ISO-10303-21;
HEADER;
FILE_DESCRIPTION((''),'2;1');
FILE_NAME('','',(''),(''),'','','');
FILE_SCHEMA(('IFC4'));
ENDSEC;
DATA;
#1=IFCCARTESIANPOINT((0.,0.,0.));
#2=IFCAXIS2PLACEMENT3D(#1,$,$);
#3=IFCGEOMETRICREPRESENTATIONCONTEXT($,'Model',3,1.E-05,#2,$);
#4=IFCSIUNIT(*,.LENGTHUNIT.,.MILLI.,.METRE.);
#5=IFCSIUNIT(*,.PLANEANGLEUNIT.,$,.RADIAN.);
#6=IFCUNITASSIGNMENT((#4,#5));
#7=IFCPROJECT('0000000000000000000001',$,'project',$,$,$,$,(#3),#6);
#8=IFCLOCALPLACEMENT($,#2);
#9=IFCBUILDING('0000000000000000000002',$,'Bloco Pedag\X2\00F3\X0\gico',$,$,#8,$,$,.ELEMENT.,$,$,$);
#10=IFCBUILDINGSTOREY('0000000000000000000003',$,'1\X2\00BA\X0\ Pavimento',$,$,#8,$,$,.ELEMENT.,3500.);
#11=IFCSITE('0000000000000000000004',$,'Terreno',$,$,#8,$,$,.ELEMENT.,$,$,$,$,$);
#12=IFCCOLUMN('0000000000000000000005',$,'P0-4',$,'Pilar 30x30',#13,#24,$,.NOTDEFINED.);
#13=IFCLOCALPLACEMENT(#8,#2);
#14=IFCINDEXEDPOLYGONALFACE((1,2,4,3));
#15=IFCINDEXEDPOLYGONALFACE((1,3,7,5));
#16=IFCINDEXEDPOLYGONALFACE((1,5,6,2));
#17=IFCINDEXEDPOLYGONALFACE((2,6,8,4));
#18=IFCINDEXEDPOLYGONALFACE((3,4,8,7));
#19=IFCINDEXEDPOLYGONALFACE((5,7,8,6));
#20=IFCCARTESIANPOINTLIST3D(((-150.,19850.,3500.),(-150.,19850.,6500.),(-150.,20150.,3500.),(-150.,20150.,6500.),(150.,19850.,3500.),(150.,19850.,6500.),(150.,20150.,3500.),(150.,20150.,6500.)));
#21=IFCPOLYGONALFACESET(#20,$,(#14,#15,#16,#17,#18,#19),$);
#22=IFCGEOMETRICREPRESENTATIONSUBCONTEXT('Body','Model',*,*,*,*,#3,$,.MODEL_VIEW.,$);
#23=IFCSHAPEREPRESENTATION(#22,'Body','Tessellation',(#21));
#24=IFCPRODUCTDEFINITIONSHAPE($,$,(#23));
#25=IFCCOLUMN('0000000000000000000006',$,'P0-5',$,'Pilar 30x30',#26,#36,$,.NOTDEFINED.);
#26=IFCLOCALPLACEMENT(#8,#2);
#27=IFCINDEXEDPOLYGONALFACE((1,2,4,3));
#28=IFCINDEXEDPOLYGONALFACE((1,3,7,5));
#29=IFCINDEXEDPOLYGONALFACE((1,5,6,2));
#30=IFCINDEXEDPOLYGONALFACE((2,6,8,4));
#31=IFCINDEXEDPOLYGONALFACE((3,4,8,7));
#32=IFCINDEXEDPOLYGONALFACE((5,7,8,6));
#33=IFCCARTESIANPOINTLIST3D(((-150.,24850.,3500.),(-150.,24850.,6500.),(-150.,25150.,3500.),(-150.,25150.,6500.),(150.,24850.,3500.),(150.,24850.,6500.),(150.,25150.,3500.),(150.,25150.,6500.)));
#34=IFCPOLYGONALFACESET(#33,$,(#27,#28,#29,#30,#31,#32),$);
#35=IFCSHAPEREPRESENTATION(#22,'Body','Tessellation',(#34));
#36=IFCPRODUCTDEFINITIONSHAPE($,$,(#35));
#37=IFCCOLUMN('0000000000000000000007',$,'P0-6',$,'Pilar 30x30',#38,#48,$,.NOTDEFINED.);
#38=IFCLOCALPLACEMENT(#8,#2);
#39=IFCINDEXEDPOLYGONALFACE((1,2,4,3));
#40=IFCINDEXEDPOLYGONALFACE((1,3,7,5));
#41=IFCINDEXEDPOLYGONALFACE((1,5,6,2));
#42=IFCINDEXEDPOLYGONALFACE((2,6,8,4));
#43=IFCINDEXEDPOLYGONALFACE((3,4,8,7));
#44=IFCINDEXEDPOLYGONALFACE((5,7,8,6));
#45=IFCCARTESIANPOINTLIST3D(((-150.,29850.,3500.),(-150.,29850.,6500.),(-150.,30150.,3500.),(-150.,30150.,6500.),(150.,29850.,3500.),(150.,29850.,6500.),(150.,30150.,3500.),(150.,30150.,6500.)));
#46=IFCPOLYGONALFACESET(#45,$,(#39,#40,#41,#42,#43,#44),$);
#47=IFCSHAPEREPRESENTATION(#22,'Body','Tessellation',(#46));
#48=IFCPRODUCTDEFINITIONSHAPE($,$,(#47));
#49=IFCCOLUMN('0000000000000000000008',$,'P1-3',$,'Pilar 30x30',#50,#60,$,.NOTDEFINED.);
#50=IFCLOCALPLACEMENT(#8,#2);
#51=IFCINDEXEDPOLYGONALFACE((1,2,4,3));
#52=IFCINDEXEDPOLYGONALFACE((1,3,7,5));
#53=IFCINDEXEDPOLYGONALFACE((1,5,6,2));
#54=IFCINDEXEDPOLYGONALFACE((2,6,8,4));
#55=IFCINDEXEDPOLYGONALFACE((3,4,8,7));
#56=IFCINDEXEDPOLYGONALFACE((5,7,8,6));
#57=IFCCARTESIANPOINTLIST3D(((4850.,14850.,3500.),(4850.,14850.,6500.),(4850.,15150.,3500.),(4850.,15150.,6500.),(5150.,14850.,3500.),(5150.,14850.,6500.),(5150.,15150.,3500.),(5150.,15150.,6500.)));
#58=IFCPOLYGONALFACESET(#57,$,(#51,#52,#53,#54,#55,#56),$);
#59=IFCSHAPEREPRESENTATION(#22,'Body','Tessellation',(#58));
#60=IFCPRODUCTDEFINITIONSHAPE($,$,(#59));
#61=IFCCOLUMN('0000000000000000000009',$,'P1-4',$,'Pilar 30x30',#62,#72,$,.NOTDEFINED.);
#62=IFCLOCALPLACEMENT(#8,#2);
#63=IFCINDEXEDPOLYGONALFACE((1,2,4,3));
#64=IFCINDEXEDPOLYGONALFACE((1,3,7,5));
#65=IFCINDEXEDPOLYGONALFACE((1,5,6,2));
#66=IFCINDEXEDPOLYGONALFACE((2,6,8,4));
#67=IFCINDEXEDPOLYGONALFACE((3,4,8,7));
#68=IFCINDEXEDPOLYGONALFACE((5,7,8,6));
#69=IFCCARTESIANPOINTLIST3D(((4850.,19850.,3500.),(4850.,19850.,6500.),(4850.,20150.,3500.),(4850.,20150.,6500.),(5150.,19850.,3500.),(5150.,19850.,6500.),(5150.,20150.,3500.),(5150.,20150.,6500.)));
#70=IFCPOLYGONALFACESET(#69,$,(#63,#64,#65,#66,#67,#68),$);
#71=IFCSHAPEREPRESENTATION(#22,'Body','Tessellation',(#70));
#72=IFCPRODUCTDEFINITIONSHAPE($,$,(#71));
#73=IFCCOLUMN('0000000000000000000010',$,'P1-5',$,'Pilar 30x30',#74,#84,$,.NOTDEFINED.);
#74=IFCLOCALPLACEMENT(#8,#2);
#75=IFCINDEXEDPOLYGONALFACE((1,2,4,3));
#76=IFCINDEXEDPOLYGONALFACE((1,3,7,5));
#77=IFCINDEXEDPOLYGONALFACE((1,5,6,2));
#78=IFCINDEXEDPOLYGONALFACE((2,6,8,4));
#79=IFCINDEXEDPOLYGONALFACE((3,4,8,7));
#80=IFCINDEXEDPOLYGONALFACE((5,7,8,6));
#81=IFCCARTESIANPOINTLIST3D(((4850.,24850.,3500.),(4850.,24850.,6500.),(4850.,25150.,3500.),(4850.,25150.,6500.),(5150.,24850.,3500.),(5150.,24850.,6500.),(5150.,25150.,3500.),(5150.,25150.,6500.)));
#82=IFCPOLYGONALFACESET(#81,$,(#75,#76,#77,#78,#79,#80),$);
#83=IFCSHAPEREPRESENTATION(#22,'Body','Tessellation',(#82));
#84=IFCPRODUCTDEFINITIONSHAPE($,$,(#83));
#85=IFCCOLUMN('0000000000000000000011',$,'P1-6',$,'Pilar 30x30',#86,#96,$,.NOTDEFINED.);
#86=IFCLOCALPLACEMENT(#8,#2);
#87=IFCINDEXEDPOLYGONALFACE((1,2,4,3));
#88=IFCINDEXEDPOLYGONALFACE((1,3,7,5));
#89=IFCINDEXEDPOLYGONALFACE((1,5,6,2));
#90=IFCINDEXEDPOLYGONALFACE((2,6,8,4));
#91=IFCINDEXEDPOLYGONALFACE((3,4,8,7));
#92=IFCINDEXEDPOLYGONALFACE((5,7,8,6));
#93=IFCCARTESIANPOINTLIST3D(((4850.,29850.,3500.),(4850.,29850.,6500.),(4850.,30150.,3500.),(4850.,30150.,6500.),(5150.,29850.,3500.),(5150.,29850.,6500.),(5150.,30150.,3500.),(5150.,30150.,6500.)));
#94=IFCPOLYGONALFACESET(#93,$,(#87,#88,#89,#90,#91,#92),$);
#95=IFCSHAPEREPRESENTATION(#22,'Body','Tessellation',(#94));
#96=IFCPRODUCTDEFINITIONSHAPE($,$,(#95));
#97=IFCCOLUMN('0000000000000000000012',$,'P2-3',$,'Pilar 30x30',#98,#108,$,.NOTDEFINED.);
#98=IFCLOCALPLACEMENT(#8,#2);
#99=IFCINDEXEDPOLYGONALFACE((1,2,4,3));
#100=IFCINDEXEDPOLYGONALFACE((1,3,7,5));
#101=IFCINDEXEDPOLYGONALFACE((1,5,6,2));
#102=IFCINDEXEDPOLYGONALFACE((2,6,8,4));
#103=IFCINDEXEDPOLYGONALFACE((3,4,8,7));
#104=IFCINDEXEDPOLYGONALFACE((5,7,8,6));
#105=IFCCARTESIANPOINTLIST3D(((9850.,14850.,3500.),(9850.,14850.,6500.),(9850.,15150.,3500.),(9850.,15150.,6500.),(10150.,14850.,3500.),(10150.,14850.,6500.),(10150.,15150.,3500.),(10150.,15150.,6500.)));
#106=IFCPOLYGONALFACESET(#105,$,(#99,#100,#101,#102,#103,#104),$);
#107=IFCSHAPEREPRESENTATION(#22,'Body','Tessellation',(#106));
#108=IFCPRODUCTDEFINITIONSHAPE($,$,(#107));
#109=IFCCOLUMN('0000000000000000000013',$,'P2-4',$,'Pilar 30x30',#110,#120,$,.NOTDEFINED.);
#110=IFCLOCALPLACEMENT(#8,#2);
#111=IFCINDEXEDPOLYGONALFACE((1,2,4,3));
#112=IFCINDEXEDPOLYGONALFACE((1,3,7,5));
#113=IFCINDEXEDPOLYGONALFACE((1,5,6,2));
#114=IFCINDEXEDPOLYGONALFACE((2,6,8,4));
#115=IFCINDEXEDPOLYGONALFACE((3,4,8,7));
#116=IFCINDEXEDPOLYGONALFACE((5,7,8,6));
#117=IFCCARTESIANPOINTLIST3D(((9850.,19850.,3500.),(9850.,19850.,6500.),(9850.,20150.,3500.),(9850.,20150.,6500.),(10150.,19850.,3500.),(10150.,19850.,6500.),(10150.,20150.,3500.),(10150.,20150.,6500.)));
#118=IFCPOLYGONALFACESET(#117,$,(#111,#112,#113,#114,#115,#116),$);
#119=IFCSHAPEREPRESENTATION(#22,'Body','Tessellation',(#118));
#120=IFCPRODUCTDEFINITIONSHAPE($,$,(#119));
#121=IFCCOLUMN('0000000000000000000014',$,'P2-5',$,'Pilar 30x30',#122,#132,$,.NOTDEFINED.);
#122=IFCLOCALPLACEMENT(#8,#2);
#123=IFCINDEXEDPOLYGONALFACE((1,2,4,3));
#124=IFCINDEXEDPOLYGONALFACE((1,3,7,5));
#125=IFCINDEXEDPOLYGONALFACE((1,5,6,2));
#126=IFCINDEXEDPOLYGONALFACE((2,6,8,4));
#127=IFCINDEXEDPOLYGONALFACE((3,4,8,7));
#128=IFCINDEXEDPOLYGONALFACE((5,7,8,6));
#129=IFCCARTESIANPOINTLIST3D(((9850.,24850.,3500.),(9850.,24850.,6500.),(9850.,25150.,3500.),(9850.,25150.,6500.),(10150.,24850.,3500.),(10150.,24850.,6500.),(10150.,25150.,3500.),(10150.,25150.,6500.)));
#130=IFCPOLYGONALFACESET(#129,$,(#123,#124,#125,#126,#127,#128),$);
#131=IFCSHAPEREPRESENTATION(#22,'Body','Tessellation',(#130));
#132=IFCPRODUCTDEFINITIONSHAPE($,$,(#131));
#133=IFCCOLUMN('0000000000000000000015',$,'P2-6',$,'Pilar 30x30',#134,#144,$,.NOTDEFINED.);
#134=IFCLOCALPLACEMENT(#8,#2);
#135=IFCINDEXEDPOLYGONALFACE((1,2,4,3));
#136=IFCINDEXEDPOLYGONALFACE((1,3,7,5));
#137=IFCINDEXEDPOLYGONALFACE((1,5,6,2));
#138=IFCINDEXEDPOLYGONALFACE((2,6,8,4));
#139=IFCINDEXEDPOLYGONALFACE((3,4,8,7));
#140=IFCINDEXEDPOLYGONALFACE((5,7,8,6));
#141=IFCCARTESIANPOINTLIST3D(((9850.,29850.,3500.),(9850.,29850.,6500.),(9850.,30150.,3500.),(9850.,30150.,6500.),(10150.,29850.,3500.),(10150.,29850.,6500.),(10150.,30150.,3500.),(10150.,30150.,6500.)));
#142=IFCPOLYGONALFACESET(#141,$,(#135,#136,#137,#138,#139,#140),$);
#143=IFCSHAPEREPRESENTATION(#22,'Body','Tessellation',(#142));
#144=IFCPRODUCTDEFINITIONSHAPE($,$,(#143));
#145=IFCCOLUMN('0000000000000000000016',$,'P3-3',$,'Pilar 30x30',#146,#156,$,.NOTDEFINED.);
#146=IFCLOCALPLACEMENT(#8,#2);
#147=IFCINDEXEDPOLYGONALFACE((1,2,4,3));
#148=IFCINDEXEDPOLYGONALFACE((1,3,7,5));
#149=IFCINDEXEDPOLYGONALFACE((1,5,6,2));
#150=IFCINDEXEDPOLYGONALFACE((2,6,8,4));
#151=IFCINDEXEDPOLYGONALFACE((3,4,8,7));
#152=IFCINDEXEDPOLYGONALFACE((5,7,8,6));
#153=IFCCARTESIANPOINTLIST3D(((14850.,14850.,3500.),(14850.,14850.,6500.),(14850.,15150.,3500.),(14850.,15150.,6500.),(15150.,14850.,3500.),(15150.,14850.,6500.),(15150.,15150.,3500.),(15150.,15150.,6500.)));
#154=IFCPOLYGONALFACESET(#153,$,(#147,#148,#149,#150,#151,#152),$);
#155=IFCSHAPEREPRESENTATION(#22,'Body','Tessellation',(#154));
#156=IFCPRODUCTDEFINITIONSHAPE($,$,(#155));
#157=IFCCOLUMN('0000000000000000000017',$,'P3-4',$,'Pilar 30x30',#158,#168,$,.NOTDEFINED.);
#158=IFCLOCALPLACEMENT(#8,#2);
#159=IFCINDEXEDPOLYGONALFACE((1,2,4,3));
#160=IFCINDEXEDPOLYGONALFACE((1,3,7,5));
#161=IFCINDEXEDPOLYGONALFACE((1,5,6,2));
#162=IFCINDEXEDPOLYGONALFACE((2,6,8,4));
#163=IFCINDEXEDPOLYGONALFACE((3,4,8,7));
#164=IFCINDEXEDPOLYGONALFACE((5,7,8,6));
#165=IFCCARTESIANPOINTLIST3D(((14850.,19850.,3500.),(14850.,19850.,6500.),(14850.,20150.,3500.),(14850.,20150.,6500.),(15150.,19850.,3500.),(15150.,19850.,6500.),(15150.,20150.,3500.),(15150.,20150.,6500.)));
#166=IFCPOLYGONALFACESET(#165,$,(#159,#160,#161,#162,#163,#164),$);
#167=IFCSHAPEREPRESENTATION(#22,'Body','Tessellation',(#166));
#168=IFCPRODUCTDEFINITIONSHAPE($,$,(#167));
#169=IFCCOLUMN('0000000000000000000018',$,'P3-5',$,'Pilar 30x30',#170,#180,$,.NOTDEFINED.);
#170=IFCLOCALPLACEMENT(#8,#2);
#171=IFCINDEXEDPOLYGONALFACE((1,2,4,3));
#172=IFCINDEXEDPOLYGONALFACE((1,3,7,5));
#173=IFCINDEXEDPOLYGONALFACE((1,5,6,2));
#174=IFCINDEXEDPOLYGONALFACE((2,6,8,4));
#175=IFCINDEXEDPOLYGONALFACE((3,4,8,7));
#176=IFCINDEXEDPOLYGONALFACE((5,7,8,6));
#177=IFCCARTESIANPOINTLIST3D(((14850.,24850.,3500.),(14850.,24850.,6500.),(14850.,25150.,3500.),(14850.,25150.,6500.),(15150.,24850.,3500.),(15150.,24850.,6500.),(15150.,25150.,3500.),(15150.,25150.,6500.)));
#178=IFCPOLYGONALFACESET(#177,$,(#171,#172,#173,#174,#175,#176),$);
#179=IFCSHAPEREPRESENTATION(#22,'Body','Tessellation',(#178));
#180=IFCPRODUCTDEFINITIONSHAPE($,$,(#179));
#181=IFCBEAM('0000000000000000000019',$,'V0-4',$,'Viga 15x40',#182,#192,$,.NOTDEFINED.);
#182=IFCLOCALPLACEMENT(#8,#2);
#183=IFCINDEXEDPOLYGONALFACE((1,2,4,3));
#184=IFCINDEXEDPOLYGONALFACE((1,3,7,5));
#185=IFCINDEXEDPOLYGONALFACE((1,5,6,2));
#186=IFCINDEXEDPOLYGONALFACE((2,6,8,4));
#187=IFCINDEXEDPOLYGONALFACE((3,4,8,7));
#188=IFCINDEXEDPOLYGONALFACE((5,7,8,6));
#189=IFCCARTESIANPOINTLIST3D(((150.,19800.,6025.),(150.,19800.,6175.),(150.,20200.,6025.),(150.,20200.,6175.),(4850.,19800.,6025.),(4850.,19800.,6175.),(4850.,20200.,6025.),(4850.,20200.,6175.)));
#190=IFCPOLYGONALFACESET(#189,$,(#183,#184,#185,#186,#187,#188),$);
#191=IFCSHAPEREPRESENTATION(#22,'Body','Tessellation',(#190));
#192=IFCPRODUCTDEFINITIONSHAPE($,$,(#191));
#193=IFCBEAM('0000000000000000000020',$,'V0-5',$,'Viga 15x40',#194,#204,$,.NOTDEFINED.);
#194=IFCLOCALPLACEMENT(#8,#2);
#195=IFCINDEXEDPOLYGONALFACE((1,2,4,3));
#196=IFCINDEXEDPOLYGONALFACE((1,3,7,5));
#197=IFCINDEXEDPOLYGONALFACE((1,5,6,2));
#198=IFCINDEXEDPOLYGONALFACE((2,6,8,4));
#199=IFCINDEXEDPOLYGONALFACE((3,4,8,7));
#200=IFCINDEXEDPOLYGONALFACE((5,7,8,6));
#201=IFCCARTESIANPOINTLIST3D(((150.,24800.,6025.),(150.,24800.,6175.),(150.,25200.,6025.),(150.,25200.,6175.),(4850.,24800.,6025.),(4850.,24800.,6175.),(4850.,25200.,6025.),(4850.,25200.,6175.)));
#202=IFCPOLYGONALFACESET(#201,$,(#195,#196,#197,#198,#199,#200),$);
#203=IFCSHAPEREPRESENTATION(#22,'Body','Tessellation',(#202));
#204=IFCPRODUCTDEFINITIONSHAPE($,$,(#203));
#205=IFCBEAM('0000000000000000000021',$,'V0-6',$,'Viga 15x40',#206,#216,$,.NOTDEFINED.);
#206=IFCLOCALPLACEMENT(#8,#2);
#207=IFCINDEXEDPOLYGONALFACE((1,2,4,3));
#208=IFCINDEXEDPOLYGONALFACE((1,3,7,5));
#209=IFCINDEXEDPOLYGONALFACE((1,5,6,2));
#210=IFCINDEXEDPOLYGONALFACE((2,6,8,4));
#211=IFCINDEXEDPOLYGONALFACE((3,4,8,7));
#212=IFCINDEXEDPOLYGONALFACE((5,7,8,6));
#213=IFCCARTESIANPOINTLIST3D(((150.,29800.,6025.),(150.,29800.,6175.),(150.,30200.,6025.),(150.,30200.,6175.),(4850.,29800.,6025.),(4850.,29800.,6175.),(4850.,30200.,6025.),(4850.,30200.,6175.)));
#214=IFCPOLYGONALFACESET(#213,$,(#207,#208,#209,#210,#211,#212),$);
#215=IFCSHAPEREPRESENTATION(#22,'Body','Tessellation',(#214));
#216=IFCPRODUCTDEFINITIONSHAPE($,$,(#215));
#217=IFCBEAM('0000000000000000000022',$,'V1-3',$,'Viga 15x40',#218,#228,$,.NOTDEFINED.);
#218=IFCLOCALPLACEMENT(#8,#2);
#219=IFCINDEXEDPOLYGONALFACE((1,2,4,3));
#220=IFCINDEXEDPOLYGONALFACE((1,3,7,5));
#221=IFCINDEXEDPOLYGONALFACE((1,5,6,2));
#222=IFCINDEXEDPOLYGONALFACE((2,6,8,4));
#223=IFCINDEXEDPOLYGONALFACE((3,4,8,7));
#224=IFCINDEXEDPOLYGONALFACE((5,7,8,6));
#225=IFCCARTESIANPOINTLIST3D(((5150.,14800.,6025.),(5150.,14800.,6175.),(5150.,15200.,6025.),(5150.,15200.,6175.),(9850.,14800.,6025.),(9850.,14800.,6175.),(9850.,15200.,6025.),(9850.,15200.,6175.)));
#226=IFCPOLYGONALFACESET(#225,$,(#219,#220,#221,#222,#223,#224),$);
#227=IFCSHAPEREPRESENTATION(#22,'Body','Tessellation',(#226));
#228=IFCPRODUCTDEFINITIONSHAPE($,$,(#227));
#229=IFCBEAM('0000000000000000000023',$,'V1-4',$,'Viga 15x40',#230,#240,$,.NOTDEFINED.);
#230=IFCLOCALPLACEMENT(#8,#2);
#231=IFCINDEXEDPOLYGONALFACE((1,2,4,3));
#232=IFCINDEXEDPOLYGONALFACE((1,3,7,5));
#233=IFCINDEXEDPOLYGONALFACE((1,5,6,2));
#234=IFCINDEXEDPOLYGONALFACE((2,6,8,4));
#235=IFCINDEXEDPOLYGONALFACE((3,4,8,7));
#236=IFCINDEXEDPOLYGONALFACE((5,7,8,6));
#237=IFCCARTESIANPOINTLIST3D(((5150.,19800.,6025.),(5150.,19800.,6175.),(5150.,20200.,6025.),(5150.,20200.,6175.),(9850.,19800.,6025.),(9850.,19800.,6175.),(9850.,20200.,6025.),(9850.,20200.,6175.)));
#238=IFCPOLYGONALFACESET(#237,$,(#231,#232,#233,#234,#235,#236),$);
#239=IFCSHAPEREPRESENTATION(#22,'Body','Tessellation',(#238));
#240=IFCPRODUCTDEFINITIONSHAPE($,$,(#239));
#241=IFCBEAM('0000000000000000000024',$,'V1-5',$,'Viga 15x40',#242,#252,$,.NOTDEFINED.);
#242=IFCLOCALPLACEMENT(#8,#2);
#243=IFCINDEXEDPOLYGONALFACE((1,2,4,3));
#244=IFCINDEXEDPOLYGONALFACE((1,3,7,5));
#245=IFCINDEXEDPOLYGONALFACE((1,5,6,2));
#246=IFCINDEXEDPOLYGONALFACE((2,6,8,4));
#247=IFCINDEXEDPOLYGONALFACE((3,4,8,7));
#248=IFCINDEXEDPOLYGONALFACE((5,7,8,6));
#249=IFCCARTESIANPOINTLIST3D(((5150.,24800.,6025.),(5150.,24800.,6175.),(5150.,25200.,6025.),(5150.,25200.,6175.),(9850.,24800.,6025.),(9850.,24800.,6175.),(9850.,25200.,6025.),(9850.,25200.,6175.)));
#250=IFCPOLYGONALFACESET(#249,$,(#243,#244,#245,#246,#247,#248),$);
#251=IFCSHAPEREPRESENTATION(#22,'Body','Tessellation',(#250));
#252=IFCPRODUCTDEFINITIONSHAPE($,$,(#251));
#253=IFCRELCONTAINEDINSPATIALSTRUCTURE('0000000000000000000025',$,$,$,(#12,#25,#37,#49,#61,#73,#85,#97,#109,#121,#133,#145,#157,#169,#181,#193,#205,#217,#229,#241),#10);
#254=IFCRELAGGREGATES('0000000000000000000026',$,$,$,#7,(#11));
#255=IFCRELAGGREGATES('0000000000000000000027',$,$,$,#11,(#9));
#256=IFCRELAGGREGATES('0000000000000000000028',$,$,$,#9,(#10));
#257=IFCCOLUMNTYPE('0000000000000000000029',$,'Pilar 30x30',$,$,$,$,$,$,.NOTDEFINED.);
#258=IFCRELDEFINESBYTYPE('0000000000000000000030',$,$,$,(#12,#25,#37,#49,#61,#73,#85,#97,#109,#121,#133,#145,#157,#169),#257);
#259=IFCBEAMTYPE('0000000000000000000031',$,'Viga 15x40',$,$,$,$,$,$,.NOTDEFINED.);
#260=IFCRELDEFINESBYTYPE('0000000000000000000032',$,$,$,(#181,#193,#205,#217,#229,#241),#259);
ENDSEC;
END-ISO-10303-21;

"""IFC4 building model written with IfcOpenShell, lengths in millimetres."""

from ifc_helpers import new_model, si_unit, frame, origin, origin_2d, place, context, subcontext, project, spatial, rectangle, extrude, type_object, element, save


model = new_model("IFC4")

# Units and contexts
model_context = context("Model", 3, precision=1e-05, world=origin())
body_context = subcontext(model_context, "Body", "Model", "MODEL_VIEW")
ifc_project = project(units=[si_unit("LENGTHUNIT", "METRE", prefix="MILLI"), si_unit("PLANEANGLEUNIT", "RADIAN")], contexts=[model_context])

# Site, building, storey
placement = place(None, origin())
site = spatial("IfcSite", under=ifc_project, at=placement, Name="Terreno", CompositionType="ELEMENT")
building = spatial("IfcBuilding", under=site, at=placement, Name="Bloco Pedagógico", CompositionType="ELEMENT")
storey = spatial("IfcBuildingStorey", under=building, at=placement, Name="1º Pavimento", CompositionType="ELEMENT", Elevation=3500.0)

# Columns
column_type = type_object("IfcColumnType", Name="Pilar 30x30", PredefinedType="NOTDEFINED")
for number, where, z_axis, x_axis, name in (
    (1, (0.0, 20000.0, 3500.0), (0.0, 0.0, 1.0), (1.0, 0.0, 0.0), "P0-4"),
    (2, (0.0, 25000.0, 3500.0), (0.0, 0.0, 1.0), (1.0, 0.0, 0.0), "P0-5"),
    (3, (0.0, 30000.0, 3500.0), (0.0, 0.0, 1.0), (1.0, 0.0, 0.0), "P0-6"),
    (4, (5000.0, 15000.0, 3500.0), (0.0, 0.0, 1.0), (1.0, 0.0, 0.0), "P1-3"),
    (5, (5000.0, 20000.0, 3500.0), (0.0, 0.0, 1.0), (1.0, 0.0, 0.0), "P1-4"),
    (6, (5000.0, 25000.0, 3500.0), (0.0, 0.0, 1.0), (1.0, 0.0, 0.0), "P1-5"),
    (7, (5000.0, 30000.0, 3500.0), (0.0, 0.0, 1.0), (1.0, 0.0, 0.0), "P1-6"),
    (8, (10000.0, 15000.0, 3500.0), (0.0, 0.0, 1.0), (1.0, 0.0, 0.0), "P2-3"),
    (9, (10000.0, 20000.0, 3500.0), (0.0, 0.0, 1.0), (1.0, 0.0, 0.0), "P2-4"),
    (10, (10000.0, 25000.0, 3500.0), (0.0, 0.0, 1.0), (1.0, 0.0, 0.0), "P2-5"),
    (11, (10000.0, 30000.0, 3500.0), (0.0, 0.0, 1.0), (1.0, 0.0, 0.0), "P2-6"),
    (12, (15000.0, 15000.0, 3500.0), (0.0, 0.0, 1.0), (1.0, 0.0, 0.0), "P3-3"),
    (13, (15000.0, 20000.0, 3500.0), (0.0, 0.0, 1.0), (1.0, 0.0, 0.0), "P3-4"),
    (14, (15000.0, 25000.0, 3500.0), (0.0, 0.0, 1.0), (1.0, 0.0, 0.0), "P3-5"),
):
    element("IfcColumn", number, at=place(None, frame(where, z_axis=z_axis, x_axis=x_axis)), inside=storey, type_object=column_type, Name=name, ObjectType="Pilar 30x30", PredefinedType="NOTDEFINED", context=body_context, shape_type="SweptSolid", body=[
        extrude(rectangle(XDim=300.0, YDim=300.0, at=origin_2d()), None, (0.0, 0.0, 1.0), 3000.0),
    ])

# Beams
beam_type = type_object("IfcBeamType", Name="Viga 15x40", PredefinedType="NOTDEFINED")
for number, where, z_axis, x_axis, name in (
    (15, (150.0, 20000.0, 6100.0), (1.0, 0.0, 0.0), (0.0, 1.0, 0.0), "V0-4"),
    (16, (150.0, 25000.0, 6100.0), (1.0, 0.0, 0.0), (0.0, 1.0, 0.0), "V0-5"),
    (17, (150.0, 30000.0, 6100.0), (1.0, 0.0, 0.0), (0.0, 1.0, 0.0), "V0-6"),
    (18, (5150.0, 15000.0, 6100.0), (1.0, 0.0, 0.0), (0.0, 1.0, 0.0), "V1-3"),
    (19, (5150.0, 20000.0, 6100.0), (1.0, 0.0, 0.0), (0.0, 1.0, 0.0), "V1-4"),
    (20, (5150.0, 25000.0, 6100.0), (1.0, 0.0, 0.0), (0.0, 1.0, 0.0), "V1-5"),
):
    element("IfcBeam", number, at=place(None, frame(where, z_axis=z_axis, x_axis=x_axis)), inside=storey, type_object=beam_type, Name=name, ObjectType="Viga 15x40", PredefinedType="NOTDEFINED", context=body_context, shape_type="SweptSolid", body=[
        extrude(rectangle(XDim=400.0, YDim=150.0, at=origin_2d()), None, (0.0, 0.0, 1.0), 4700.0),
    ])

save(model, "model.ifc")
